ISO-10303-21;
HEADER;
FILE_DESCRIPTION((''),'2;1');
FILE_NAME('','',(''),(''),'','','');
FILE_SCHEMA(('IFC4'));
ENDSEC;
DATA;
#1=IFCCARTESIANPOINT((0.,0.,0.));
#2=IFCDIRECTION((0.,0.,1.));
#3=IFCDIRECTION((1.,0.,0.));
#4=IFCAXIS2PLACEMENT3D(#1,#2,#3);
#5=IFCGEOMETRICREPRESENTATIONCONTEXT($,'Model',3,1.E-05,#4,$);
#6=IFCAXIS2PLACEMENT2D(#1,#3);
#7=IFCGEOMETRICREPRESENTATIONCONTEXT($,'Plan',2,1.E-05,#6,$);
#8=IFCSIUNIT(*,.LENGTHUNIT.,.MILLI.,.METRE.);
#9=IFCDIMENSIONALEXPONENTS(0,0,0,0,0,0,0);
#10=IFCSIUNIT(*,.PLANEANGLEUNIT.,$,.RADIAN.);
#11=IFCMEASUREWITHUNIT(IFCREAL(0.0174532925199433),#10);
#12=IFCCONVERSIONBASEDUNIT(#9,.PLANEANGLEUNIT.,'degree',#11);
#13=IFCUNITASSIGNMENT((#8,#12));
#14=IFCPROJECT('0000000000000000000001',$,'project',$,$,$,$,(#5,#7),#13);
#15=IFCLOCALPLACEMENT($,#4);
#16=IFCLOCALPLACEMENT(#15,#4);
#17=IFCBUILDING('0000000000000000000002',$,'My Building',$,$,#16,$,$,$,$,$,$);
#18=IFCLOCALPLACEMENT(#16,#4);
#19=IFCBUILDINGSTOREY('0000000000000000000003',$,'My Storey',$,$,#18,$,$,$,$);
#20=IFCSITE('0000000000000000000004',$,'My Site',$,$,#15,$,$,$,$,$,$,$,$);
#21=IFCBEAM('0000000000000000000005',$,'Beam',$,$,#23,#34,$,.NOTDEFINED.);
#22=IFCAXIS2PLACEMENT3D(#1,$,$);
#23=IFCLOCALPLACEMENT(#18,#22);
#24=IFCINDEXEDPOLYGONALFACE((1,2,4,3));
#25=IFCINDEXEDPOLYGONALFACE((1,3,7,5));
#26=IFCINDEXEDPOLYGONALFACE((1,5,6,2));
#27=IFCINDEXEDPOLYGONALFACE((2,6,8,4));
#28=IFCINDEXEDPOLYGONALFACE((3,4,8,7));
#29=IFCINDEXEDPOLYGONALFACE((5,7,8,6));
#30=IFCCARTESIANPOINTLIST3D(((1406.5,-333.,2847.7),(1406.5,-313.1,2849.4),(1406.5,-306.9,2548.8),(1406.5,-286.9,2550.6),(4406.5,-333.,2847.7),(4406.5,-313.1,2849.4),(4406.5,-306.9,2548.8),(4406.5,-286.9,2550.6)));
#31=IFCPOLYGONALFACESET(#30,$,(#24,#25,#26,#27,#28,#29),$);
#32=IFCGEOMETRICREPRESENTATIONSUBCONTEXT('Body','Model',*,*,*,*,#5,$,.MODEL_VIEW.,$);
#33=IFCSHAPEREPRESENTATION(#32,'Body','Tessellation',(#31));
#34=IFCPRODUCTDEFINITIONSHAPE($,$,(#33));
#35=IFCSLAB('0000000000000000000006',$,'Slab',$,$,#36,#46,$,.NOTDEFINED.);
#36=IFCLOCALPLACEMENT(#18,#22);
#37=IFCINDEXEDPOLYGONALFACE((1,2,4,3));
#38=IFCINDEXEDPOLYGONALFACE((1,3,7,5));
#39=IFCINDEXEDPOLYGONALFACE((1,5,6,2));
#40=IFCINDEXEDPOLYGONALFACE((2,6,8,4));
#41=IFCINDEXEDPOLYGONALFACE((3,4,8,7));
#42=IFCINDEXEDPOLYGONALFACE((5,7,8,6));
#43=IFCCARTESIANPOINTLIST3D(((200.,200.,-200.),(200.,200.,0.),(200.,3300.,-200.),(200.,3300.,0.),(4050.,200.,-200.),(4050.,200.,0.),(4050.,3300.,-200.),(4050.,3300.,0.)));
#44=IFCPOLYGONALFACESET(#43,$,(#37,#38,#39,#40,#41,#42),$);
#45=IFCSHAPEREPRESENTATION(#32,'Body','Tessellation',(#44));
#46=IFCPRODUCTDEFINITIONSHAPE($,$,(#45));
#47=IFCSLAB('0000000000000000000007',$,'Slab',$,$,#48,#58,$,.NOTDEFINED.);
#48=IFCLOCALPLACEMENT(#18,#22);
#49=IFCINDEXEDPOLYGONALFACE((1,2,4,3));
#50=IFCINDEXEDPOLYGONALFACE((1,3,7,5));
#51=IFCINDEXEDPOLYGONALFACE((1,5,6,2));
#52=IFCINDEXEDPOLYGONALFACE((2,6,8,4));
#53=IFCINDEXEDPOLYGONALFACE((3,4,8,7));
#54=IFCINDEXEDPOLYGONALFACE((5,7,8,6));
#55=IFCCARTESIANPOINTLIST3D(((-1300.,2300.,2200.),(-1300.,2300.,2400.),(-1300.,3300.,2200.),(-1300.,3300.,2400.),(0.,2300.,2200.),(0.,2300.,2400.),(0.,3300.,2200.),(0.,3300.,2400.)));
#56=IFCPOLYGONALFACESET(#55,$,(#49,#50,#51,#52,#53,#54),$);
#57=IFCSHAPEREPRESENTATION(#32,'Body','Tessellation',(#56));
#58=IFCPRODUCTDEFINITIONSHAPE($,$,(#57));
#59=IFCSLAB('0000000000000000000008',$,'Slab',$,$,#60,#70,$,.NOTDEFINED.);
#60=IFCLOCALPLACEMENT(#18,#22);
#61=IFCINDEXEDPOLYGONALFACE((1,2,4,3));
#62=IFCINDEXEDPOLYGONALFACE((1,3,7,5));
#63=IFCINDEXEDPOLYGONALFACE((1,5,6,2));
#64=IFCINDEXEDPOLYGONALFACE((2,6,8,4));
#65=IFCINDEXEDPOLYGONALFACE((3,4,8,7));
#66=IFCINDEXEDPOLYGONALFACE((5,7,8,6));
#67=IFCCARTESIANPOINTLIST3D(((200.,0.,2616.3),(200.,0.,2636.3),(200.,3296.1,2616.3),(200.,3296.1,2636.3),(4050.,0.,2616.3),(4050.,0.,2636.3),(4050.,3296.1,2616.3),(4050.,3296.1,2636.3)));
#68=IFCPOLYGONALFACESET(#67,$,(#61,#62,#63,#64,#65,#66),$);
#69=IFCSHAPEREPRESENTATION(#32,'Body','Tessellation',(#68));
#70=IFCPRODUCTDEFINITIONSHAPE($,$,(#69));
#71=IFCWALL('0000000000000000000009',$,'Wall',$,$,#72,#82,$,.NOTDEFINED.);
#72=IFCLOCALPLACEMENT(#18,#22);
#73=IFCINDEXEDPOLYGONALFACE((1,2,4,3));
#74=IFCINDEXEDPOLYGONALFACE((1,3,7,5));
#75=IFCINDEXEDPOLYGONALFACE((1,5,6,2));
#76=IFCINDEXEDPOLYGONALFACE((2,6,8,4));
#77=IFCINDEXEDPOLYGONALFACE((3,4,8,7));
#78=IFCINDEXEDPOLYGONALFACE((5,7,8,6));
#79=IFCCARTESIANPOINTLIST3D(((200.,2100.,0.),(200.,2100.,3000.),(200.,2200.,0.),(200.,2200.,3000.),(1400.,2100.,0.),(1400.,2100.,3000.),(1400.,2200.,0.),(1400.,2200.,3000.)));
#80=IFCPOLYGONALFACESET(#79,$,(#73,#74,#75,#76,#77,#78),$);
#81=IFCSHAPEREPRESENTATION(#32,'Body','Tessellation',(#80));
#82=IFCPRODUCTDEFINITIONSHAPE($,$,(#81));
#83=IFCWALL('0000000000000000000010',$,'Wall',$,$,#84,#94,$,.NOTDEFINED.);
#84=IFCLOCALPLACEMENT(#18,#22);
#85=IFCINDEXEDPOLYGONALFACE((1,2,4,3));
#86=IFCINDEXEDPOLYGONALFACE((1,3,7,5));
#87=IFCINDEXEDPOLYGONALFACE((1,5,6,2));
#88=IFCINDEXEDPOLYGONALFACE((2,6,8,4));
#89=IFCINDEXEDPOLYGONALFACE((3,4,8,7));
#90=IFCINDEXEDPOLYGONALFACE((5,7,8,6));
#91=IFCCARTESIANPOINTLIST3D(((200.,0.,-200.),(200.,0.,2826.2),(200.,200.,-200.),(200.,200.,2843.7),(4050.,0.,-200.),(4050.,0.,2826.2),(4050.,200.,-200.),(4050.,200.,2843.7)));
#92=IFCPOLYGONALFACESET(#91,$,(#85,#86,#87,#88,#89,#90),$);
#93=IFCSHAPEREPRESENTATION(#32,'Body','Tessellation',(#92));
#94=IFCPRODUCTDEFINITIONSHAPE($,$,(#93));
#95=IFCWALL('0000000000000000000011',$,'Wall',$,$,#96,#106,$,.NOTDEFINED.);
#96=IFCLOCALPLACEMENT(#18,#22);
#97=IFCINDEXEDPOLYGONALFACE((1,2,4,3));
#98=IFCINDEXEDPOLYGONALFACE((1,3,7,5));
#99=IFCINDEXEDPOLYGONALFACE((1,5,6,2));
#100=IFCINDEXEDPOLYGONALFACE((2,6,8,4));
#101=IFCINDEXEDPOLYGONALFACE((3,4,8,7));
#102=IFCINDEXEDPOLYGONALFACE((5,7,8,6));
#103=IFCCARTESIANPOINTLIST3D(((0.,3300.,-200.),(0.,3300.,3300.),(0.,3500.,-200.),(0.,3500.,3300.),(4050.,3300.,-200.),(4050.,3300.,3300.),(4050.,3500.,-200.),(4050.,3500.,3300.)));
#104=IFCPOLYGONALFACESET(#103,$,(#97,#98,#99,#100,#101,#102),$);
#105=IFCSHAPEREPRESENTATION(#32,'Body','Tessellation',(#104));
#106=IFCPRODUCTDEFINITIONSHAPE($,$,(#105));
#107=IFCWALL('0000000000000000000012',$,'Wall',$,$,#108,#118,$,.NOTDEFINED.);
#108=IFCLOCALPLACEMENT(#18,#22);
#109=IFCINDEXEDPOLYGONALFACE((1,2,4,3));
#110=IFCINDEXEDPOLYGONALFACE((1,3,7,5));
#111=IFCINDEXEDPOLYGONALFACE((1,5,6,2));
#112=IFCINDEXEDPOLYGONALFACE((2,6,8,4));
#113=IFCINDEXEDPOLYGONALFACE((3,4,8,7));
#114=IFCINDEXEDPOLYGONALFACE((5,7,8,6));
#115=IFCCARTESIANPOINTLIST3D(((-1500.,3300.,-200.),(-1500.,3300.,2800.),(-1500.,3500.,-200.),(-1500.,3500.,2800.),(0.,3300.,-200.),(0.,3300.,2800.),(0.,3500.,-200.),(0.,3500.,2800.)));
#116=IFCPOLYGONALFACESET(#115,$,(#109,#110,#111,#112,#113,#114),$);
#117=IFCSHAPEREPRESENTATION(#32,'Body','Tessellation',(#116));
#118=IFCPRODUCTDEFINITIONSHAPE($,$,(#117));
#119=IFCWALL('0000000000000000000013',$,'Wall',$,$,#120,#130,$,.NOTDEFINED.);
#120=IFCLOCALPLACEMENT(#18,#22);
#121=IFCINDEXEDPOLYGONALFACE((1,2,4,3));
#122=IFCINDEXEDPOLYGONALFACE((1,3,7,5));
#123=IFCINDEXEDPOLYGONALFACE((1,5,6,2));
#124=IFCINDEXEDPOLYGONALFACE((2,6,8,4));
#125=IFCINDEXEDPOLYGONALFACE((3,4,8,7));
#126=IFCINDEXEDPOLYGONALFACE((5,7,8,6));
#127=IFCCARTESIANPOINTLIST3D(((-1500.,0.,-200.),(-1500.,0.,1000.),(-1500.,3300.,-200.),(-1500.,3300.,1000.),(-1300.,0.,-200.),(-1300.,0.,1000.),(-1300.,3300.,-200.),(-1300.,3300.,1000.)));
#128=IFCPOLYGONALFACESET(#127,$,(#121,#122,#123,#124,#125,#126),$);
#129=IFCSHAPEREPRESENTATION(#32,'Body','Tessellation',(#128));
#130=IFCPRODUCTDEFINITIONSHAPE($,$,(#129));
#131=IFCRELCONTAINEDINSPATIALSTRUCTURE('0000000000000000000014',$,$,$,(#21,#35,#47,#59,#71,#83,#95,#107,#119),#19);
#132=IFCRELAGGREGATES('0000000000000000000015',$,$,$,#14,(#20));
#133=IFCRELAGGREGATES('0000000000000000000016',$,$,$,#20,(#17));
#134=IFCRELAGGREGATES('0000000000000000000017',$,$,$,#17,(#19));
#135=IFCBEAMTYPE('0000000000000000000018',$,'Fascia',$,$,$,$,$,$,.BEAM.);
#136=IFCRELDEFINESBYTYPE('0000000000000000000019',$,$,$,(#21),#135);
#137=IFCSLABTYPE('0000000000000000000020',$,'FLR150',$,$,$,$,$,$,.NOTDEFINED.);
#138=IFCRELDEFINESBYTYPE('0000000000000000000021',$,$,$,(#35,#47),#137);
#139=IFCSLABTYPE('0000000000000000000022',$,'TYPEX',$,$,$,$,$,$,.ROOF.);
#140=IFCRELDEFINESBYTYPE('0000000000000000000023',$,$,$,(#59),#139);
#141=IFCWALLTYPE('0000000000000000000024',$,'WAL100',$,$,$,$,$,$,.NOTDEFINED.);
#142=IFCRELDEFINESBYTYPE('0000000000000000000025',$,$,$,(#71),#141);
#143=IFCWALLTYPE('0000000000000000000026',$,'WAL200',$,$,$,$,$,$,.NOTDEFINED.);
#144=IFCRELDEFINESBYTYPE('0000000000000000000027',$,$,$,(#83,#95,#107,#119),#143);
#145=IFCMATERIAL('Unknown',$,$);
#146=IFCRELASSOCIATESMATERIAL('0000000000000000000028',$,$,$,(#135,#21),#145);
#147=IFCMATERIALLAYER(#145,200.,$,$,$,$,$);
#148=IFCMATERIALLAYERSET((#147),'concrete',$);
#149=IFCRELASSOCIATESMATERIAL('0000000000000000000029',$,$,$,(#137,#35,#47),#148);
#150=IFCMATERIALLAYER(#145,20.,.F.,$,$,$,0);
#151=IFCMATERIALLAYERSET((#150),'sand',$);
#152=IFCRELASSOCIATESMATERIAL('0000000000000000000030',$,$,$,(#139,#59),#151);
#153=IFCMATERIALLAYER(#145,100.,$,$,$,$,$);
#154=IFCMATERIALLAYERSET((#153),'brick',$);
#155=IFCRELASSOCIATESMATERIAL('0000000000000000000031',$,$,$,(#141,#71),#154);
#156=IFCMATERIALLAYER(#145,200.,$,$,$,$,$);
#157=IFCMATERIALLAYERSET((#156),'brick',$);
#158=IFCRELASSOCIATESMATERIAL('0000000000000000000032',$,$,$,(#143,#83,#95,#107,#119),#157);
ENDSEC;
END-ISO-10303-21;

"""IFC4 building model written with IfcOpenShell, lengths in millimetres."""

from ifc_helpers import new_model, entity, si_unit, converted_unit, frame, frame_2d, origin_with_axes, place, context, subcontext, project, spatial, line, indexed_curve, rectangle, outline, extrude, clip, halfspace, material, layer, layer_set, layer_usage, material_profile, profile_set, profile_usage, type_object, element, save


model = new_model("IFC4")

# Units and contexts
model_context = context("Model", 3, precision=1e-05, world=origin_with_axes())
plan_context = context("Plan", 2, precision=1e-05, world=frame_2d((0.0, 0.0, 0.0), x_axis=(1.0, 0.0, 0.0)))
body_context = subcontext(model_context, "Body", "Model", "MODEL_VIEW")
ifc_project = project(units=[si_unit("LENGTHUNIT", "METRE", prefix="MILLI"), converted_unit("PLANEANGLEUNIT", "degree", entity("IfcReal", 0.0174532925199433), si_unit("PLANEANGLEUNIT", "RADIAN"), dimensions=[0, 0, 0, 0, 0, 0, 0])], contexts=[model_context, plan_context])

# Site, building, storey
site_placement = place(None, origin_with_axes())
site = spatial("IfcSite", under=ifc_project, at=site_placement, Name="My Site")
building_placement = place(site_placement, origin_with_axes())
building = spatial("IfcBuilding", under=site, at=building_placement, Name="My Building")
storey_placement = place(building_placement, origin_with_axes())
storey = spatial("IfcBuildingStorey", under=building, at=storey_placement, Name="My Storey")

# Shared definitions
ifc_material = material(Name="Unknown")

# Beam
ifc_material_profile_1 = material_profile(ifc_material, rectangle(XDim=20.0, YDim=300.0))
ifc_profile_set_1 = profile_set([ifc_material_profile_1], Name="sand")
ifc_profile_usage_1 = profile_usage(ifc_profile_set_1, cardinal=5)
beam_type_1 = type_object("IfcBeamType", Name="Fascia", PredefinedType="BEAM", material=ifc_profile_set_1)
beam_1_placement = place(storey_placement, frame((1406.5, -310.0, 2699.1), z_axis=(1.0, 0.0, 0.0), x_axis=(0.0, 0.996195, 0.087156)))
element("IfcBeam", 1, at=beam_1_placement, inside=storey, type_object=beam_type_1, material=ifc_profile_usage_1, Name="Beam", PredefinedType="NOTDEFINED", context=body_context, shape_type="SweptSolid", body=[
    extrude(rectangle(XDim=20.0, YDim=300.0), origin_with_axes(), (0.0, 0.0, 1.0), 3000.0),
])

# Slabs
ifc_layer_1 = layer(ifc_material, 200.0)
ifc_layer_set_1 = layer_set([ifc_layer_1], Name="concrete")
ifc_layer_usage_1 = layer_usage(ifc_layer_set_1, "AXIS3", "POSITIVE", 0.0)
slab_type_1 = type_object("IfcSlabType", Name="FLR150", PredefinedType="NOTDEFINED", material=ifc_layer_set_1)
slab_1_placement = place(storey_placement, frame((200.0, 200.0, -200.0), z_axis=(0.0, 0.0, 1.0), x_axis=(1.0, 0.0, 0.0)))
element("IfcSlab", 2, at=slab_1_placement, inside=storey, type_object=slab_type_1, material=ifc_layer_usage_1, Name="Slab", PredefinedType="NOTDEFINED", context=body_context, shape_type="SweptSolid", body=[
    extrude(outline(indexed_curve([(0.0, 0.0), (3850.0, 0.0), (3850.0, 3100.0), (0.0, 3100.0)], segments=[line(3, 2), line(2, 1), line(1, 4), line(4, 3)], self_intersect=False)), None, (0.0, 0.0, 1.0), 200.0),
])
ifc_layer_usage_2 = layer_usage(ifc_layer_set_1, "AXIS3", "POSITIVE", 0.0)
slab_2_placement = place(storey_placement, frame((-1300.0, 2300.0, 2200.0), z_axis=(0.0, 0.0, 1.0), x_axis=(1.0, 0.0, 0.0)))
element("IfcSlab", 3, at=slab_2_placement, inside=storey, type_object=slab_type_1, material=ifc_layer_usage_2, Name="Slab", PredefinedType="NOTDEFINED", context=body_context, shape_type="SweptSolid", body=[
    extrude(outline(indexed_curve([(0.0, 0.0), (1300.0, 0.0), (1300.0, 1000.0), (0.0, 1000.0)], segments=[line(3, 2), line(2, 1), line(1, 4), line(4, 3)], self_intersect=False)), None, (0.0, 0.0, 1.0), 200.0),
])
ifc_layer_2 = layer(ifc_material, 20.0, ventilated=False, Priority=0)
ifc_layer_set_2 = layer_set([ifc_layer_2], Name="sand")
ifc_layer_usage_3 = layer_usage(ifc_layer_set_2, "AXIS3", "POSITIVE", 0.0)
slab_type_2 = type_object("IfcSlabType", Name="TYPEX", PredefinedType="ROOF", material=ifc_layer_set_2)
slab_3_placement = place(storey_placement, frame((200.0, 0.0, 2616.3), z_axis=(0.0, 0.0, 1.0), x_axis=(1.0, 0.0, 0.0)))
element("IfcSlab", 4, at=slab_3_placement, inside=storey, type_object=slab_type_2, material=ifc_layer_usage_3, Name="Slab", PredefinedType="NOTDEFINED", context=body_context, shape_type="SweptSolid", body=[
    extrude(outline(indexed_curve([(0.0, 0.0), (3850.0, 0.0), (3850.0, 3296.1), (0.0, 3296.1)], segments=[line(3, 2), line(2, 1), line(1, 4), line(4, 3)], self_intersect=False)), None, (0.0, 0.0, 1.0), 20.0),
])

# Walls
ifc_layer_3 = layer(ifc_material, 100.0)
ifc_layer_set_3 = layer_set([ifc_layer_3], Name="brick")
ifc_layer_usage_4 = layer_usage(ifc_layer_set_3, "AXIS2", "POSITIVE", 0.0)
wall_type_1 = type_object("IfcWallType", Name="WAL100", PredefinedType="NOTDEFINED", material=ifc_layer_set_3)
wall_1_placement = place(storey_placement, frame((200.0, 2100.0, 0.0), z_axis=(0.0, 0.0, 1.0), x_axis=(1.0, 0.0, 0.0)))
element("IfcWall", 5, at=wall_1_placement, inside=storey, type_object=wall_type_1, material=ifc_layer_usage_4, Name="Wall", PredefinedType="NOTDEFINED", context=body_context, shape_type="SweptSolid", body=[
    extrude(outline(indexed_curve([(0.0, 0.0), (0.0, 100.0), (1200.0, 100.0), (1200.0, 0.0), (0.0, 0.0)], self_intersect=False)), origin_with_axes(), (0.0, 0.0, 1.0), 3000.0),
])
ifc_layer_4 = layer(ifc_material, 200.0)
ifc_layer_set_4 = layer_set([ifc_layer_4], Name="brick")
ifc_layer_usage_5 = layer_usage(ifc_layer_set_4, "AXIS2", "POSITIVE", 0.0)
wall_type_2 = type_object("IfcWallType", Name="WAL200", PredefinedType="NOTDEFINED", material=ifc_layer_set_4)
wall_2_placement = place(storey_placement, frame((200.0, 0.0, -200.0), z_axis=(0.0, 0.0, 1.0), x_axis=(1.0, 0.0, 0.0)))
element("IfcWall", 6, at=wall_2_placement, inside=storey, type_object=wall_type_2, material=ifc_layer_usage_5, Name="Wall", PredefinedType="NOTDEFINED", context=body_context, shape_type="Clipping", body=[
    clip(extrude(outline(indexed_curve([(0.0, 0.0), (0.0, 200.0), (3850.0, 200.0), (3850.0, 0.0), (0.0, 0.0)], self_intersect=False)), origin_with_axes(), (0.0, 0.0, 1.0), 3043.7), halfspace(frame((0.0, 200.0, 3043.7), z_axis=(0.0, -0.087156, 0.996195), x_axis=(1.0, 0.0, 0.0)), False)),
])
ifc_layer_usage_6 = layer_usage(ifc_layer_set_4, "AXIS2", "POSITIVE", 0.0)
wall_3_placement = place(storey_placement, frame((4050.0, 3500.0, -200.0), z_axis=(0.0, 0.0, 1.0), x_axis=(-1.0, 0.0, 0.0)))
element("IfcWall", 7, at=wall_3_placement, inside=storey, type_object=wall_type_2, material=ifc_layer_usage_6, Name="Wall", PredefinedType="NOTDEFINED", context=body_context, shape_type="SweptSolid", body=[
    extrude(outline(indexed_curve([(0.0, 0.0), (0.0, 200.0), (4050.0, 200.0), (4050.0, 0.0), (0.0, 0.0)], self_intersect=False)), origin_with_axes(), (0.0, 0.0, 1.0), 3500.0),
])
ifc_layer_usage_7 = layer_usage(ifc_layer_set_4, "AXIS2", "POSITIVE", 0.0)
wall_4_placement = place(storey_placement, frame((0.0, 3500.0, -200.0), z_axis=(0.0, 0.0, 1.0), x_axis=(-1.0, 0.0, 0.0)))
element("IfcWall", 8, at=wall_4_placement, inside=storey, type_object=wall_type_2, material=ifc_layer_usage_7, Name="Wall", PredefinedType="NOTDEFINED", context=body_context, shape_type="SweptSolid", body=[
    extrude(outline(indexed_curve([(0.0, 0.0), (0.0, 200.0), (1500.0, 200.0), (1500.0, 0.0), (0.0, 0.0)], self_intersect=False)), origin_with_axes(), (0.0, 0.0, 1.0), 3000.0),
])
ifc_layer_usage_8 = layer_usage(ifc_layer_set_4, "AXIS2", "POSITIVE", 0.0)
wall_5_placement = place(storey_placement, frame((-1500.0, 3300.0, -200.0), z_axis=(0.0, 0.0, 1.0), x_axis=(0.0, -1.0, 0.0)))
element("IfcWall", 9, at=wall_5_placement, inside=storey, type_object=wall_type_2, material=ifc_layer_usage_8, Name="Wall", PredefinedType="NOTDEFINED", context=body_context, shape_type="SweptSolid", body=[
    extrude(outline(indexed_curve([(0.0, 0.0), (0.0, 200.0), (3300.0, 200.0), (3300.0, 0.0), (0.0, 0.0)], self_intersect=False)), origin_with_axes(), (0.0, 0.0, 1.0), 1200.0),
])

save(model, "model.ifc")
